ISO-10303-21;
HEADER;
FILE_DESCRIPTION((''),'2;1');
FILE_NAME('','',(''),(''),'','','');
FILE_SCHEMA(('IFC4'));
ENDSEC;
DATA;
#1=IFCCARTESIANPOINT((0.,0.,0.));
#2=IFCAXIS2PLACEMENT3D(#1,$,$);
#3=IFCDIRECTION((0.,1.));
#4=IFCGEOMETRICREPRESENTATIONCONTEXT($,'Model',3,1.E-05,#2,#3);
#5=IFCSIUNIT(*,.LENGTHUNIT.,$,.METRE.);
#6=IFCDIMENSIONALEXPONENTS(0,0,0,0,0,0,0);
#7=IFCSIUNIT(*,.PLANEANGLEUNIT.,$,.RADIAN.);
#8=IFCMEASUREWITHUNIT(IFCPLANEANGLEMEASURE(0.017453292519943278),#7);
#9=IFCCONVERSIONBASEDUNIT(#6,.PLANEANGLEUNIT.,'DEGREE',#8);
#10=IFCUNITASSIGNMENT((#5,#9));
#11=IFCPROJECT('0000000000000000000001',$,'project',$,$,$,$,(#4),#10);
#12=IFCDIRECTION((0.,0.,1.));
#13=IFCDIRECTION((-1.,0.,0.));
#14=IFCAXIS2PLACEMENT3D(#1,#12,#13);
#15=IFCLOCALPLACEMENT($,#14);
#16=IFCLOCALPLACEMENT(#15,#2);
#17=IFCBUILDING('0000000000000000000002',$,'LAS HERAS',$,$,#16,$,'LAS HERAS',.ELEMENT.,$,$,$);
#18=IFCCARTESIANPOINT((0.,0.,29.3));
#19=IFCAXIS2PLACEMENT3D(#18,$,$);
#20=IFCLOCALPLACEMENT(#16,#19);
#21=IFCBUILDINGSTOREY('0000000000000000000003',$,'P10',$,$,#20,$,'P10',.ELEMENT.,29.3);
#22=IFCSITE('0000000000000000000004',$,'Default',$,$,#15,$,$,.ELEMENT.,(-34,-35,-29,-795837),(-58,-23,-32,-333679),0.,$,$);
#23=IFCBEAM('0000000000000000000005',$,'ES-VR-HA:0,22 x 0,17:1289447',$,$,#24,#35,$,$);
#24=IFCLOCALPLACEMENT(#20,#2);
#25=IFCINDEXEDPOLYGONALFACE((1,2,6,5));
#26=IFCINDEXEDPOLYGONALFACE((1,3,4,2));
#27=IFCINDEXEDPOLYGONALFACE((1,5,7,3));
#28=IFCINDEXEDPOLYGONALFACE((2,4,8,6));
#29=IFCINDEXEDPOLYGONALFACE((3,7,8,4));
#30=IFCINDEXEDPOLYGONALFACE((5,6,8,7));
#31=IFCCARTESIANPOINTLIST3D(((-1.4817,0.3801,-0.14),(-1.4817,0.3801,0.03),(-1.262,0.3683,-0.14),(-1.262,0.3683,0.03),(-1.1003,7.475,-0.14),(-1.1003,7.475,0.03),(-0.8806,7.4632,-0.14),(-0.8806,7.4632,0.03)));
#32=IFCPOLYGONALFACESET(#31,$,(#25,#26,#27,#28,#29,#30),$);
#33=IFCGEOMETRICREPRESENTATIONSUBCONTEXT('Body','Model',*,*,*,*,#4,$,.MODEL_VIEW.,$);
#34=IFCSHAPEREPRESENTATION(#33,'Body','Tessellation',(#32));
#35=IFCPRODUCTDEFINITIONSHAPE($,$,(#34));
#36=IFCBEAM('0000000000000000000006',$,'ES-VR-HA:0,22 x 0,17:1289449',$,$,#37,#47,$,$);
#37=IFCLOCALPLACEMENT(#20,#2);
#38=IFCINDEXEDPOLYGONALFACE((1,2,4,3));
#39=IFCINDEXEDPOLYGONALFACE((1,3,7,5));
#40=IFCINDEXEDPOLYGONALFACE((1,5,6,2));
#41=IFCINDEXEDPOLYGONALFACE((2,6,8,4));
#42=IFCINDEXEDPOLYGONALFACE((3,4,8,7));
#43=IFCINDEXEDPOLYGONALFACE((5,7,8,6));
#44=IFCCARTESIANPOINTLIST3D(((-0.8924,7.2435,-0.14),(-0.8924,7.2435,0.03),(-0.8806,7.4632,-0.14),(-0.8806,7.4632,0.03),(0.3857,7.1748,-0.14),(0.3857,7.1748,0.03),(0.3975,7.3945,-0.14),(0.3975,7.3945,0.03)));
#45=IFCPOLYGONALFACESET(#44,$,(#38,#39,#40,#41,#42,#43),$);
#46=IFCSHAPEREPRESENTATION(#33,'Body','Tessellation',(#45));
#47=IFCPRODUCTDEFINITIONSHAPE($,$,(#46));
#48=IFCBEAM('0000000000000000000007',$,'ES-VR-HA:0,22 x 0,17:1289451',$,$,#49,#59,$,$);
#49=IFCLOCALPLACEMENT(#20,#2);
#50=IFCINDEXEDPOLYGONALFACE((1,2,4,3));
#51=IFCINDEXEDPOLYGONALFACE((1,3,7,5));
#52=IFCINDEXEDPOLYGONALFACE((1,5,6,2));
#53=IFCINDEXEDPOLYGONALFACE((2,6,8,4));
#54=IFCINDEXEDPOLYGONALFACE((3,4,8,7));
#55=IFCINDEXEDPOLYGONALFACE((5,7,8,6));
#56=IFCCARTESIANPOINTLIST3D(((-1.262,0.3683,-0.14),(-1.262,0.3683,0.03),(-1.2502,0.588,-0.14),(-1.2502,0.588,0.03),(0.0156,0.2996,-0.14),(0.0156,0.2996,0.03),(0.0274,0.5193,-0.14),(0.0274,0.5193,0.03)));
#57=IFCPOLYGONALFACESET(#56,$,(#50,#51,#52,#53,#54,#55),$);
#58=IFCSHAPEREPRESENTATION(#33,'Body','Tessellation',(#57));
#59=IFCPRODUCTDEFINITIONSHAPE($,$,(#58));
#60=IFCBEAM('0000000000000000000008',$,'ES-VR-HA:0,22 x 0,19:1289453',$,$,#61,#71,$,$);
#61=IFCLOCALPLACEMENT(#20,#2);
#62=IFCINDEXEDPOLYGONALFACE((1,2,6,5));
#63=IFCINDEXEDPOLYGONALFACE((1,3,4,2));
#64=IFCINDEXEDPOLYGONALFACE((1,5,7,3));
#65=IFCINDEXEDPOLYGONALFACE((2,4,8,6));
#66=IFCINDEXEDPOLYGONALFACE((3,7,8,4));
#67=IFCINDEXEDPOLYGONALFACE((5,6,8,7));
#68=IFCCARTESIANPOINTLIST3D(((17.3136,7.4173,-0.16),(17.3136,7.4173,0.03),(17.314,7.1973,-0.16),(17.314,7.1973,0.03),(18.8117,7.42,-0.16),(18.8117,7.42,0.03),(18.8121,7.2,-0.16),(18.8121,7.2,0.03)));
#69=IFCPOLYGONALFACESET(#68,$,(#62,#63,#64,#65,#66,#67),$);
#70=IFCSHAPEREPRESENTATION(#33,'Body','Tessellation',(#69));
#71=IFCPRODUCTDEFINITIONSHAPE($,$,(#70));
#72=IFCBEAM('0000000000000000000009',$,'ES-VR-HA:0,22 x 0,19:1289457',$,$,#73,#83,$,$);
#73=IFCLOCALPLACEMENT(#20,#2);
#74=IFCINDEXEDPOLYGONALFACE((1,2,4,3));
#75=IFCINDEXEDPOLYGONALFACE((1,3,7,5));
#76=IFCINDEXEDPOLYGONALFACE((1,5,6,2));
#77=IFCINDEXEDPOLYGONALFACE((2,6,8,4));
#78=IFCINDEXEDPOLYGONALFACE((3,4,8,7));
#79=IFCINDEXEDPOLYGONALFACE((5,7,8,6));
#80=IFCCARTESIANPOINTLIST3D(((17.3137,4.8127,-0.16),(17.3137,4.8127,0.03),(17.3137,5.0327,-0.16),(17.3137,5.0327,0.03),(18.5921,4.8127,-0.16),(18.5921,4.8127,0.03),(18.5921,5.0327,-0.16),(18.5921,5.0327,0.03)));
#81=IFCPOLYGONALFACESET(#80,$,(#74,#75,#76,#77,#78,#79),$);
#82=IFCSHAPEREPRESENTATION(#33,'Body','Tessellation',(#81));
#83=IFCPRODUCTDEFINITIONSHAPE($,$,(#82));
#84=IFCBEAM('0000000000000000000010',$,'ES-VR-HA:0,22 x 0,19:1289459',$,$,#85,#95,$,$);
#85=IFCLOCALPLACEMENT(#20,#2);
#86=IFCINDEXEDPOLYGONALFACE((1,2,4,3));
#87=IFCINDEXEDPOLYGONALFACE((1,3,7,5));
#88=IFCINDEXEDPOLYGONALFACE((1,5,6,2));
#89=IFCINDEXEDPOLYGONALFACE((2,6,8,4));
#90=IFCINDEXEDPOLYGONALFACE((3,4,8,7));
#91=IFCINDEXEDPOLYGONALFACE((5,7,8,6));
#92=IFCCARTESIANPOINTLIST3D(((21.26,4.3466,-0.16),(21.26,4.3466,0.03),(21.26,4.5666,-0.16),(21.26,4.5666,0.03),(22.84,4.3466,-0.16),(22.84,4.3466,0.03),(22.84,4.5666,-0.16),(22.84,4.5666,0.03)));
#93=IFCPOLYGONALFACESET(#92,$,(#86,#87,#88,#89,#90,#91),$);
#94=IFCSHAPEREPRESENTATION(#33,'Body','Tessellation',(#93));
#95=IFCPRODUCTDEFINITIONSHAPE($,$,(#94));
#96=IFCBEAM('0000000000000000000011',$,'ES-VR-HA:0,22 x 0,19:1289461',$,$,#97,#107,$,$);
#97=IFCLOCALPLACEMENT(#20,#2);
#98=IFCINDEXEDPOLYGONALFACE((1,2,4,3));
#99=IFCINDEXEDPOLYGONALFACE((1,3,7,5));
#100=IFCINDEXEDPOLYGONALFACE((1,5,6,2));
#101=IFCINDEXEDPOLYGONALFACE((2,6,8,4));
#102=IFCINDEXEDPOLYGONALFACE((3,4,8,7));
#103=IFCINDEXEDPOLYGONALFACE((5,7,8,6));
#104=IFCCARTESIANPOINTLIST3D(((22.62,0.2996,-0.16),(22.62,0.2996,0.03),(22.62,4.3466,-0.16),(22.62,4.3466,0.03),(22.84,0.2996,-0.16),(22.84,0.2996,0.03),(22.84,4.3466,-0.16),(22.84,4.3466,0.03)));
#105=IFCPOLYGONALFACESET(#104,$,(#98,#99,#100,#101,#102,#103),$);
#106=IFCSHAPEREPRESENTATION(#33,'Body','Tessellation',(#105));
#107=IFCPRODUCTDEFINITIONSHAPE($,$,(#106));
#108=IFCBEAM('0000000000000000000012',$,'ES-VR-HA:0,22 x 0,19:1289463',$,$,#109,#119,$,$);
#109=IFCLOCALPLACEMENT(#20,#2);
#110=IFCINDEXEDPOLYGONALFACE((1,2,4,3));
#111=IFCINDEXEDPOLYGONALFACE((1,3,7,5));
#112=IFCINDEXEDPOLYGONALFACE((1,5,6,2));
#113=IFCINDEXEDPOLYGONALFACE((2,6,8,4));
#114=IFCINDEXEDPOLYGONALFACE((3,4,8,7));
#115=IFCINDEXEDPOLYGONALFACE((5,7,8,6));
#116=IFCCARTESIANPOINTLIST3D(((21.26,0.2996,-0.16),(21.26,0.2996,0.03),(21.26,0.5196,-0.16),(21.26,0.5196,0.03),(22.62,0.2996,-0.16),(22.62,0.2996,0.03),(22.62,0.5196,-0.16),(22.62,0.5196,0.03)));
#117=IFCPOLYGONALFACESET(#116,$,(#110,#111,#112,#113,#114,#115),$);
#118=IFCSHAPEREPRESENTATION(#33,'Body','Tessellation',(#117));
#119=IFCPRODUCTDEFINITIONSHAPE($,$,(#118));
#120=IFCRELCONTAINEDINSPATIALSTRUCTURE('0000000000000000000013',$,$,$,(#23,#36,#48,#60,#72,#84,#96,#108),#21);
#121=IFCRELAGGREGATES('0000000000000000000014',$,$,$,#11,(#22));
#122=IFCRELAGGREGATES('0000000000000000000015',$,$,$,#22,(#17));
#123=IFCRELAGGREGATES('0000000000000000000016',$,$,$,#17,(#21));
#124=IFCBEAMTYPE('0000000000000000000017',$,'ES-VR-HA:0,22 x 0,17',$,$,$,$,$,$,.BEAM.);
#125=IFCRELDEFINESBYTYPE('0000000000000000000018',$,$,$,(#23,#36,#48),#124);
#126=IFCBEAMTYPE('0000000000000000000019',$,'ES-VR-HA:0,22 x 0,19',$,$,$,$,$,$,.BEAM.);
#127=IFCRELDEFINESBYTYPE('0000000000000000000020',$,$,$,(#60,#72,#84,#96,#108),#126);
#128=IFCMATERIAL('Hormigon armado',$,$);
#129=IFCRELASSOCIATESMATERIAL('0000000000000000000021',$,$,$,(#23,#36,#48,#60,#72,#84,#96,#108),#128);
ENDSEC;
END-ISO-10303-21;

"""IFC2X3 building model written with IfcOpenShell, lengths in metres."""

from ifc_helpers import new_model, entity, si_unit, converted_unit, direction, frame, frame_2d, origin, origin_2d_with_axis, place, context, subcontext, project, spatial, rectangle, extrude, material, type_object, element, save


model = new_model("IFC2X3")

# Units and contexts
model_context = context("Model", 3, precision=1e-05, world=origin(), true_north=direction((0.0, 1.0)))
body_context = subcontext(model_context, "Body", "Model", "MODEL_VIEW")
ifc_project = project(units=[si_unit("LENGTHUNIT", "METRE"), converted_unit("PLANEANGLEUNIT", "DEGREE", entity("IfcPlaneAngleMeasure", 0.017453292519943278), si_unit("PLANEANGLEUNIT", "RADIAN"), dimensions=[0, 0, 0, 0, 0, 0, 0])], contexts=[model_context])

# Site, building, storey
site_placement = place(None, frame((0.0, 0.0, 0.0), z_axis=(0.0, 0.0, 1.0), x_axis=(-1.0, 0.0, 0.0)))
site = spatial("IfcSite", under=ifc_project, at=site_placement, Name="Default", CompositionType="ELEMENT", RefLatitude=(-34, -35, -29, -795837), RefLongitude=(-58, -23, -32, -333679), RefElevation=0.0)
building_placement = place(site_placement, origin())
building = spatial("IfcBuilding", under=site, at=building_placement, Name="LAS HERAS", LongName="LAS HERAS", CompositionType="ELEMENT")
storey_placement = place(building_placement, frame((0.0, 0.0, 29.3)))
storey = spatial("IfcBuildingStorey", under=building, at=storey_placement, Name="P10", LongName="P10", CompositionType="ELEMENT", Elevation=29.3)

# Beams
ifc_material = material(Name="Hormigon armado")
beam_type_1 = type_object("IfcBeamType", Name="ES-VR-HA:0,22 x 0,17", PredefinedType="BEAM")
beam_1_placement = place(storey_placement, frame((-0.9963, 7.3593, 0.03), z_axis=(0.0, 0.0, 1.0), x_axis=(-0.05369, -0.998558, 0.0)))
element("IfcBeam", 1, at=beam_1_placement, inside=storey, type_object=beam_type_1, material=ifc_material, Name="ES-VR-HA:0,22 x 0,17:1289447", context=body_context, shape_type="SweptSolid", body=[
    extrude(rectangle(XDim=0.17, YDim=0.22, at=frame_2d((0.0, 0.0), x_axis=(1.0, 0.0))), frame((-0.11, 0.0, -0.085), z_axis=(1.0, 0.0, 0.0), x_axis=(0.0, 0.0, -1.0)), (0.0, 0.0, 1.0), 7.1052),
])
beam_2_placement = place(storey_placement, frame((0.3916, 7.2846, 0.03), z_axis=(0.0, 0.0, 1.0), x_axis=(-0.998558, 0.05368, 0.0)))
element("IfcBeam", 2, at=beam_2_placement, inside=storey, type_object=beam_type_1, material=ifc_material, Name="ES-VR-HA:0,22 x 0,17:1289449", context=body_context, shape_type="SweptSolid", body=[
    extrude(rectangle(XDim=0.17, YDim=0.22, at=frame_2d((0.0, 0.0), x_axis=(1.0, 0.0))), frame((0.0, 0.0, -0.085), z_axis=(1.0, 0.0, 0.0), x_axis=(0.0, 0.0, -1.0)), (0.0, 0.0, 1.0), 1.28),
])
beam_3_placement = place(storey_placement, frame((0.0215, 0.4094, 0.03), z_axis=(0.0, 0.0, 1.0), x_axis=(-0.998558, 0.05369, 0.0)))
element("IfcBeam", 3, at=beam_3_placement, inside=storey, type_object=beam_type_1, material=ifc_material, Name="ES-VR-HA:0,22 x 0,17:1289451", context=body_context, shape_type="SweptSolid", body=[
    extrude(rectangle(XDim=0.17, YDim=0.22, at=frame_2d((0.0, 0.0), x_axis=(1.0, 0.0))), frame((0.0, 0.0, -0.085), z_axis=(1.0, 0.0, 0.0), x_axis=(0.0, 0.0, -1.0)), (0.0, 0.0, 1.0), 1.2795),
])
beam_type_2 = type_object("IfcBeamType", Name="ES-VR-HA:0,22 x 0,19", PredefinedType="BEAM")
beam_4_placement = place(storey_placement, frame((17.3138, 7.3073, 0.03), z_axis=(0.0, 0.0, 1.0), x_axis=(0.999998, 0.001781, 0.0)))
element("IfcBeam", 4, at=beam_4_placement, inside=storey, type_object=beam_type_2, material=ifc_material, Name="ES-VR-HA:0,22 x 0,19:1289453", context=body_context, shape_type="SweptSolid", body=[
    extrude(rectangle(XDim=0.19, YDim=0.22, at=frame_2d((0.0, 0.0), x_axis=(1.0, 0.0))), frame((0.0, 0.0, -0.095), z_axis=(1.0, 0.0, 0.0), x_axis=(0.0, 0.0, -1.0)), (0.0, 0.0, 1.0), 1.4981),
])
beam_5_placement = place(storey_placement, frame((17.3137, 4.9227, 0.03)))
element("IfcBeam", 5, at=beam_5_placement, inside=storey, type_object=beam_type_2, material=ifc_material, Name="ES-VR-HA:0,22 x 0,19:1289457", context=body_context, shape_type="SweptSolid", body=[
    extrude(rectangle(XDim=0.19, YDim=0.22, at=frame_2d((0.0, 0.0), x_axis=(1.0, 0.0))), frame((0.0, 0.0, -0.095), z_axis=(1.0, 0.0, 0.0), x_axis=(0.0, 0.0, -1.0)), (0.0, 0.0, 1.0), 1.2784),
])
beam_6_placement = place(storey_placement, frame((21.26, 4.4566, 0.03)))
element("IfcBeam", 6, at=beam_6_placement, inside=storey, type_object=beam_type_2, material=ifc_material, Name="ES-VR-HA:0,22 x 0,19:1289459", context=body_context, shape_type="SweptSolid", body=[
    extrude(rectangle(XDim=0.19, YDim=0.22, at=origin_2d_with_axis()), frame((0.0, 0.0, -0.095), z_axis=(1.0, 0.0, 0.0), x_axis=(0.0, 0.0, -1.0)), (0.0, 0.0, 1.0), 1.58),
])
beam_7_placement = place(storey_placement, frame((22.73, 4.4566, 0.03), z_axis=(0.0, 0.0, 1.0), x_axis=(0.0, -1.0, 0.0)))
element("IfcBeam", 7, at=beam_7_placement, inside=storey, type_object=beam_type_2, material=ifc_material, Name="ES-VR-HA:0,22 x 0,19:1289461", context=body_context, shape_type="SweptSolid", body=[
    extrude(rectangle(XDim=0.19, YDim=0.22, at=frame_2d((0.0, 0.0), x_axis=(1.0, 0.0))), frame((0.11, 0.0, -0.095), z_axis=(1.0, 0.0, 0.0), x_axis=(0.0, 0.0, -1.0)), (0.0, 0.0, 1.0), 4.0471),
])
beam_8_placement = place(storey_placement, frame((21.26, 0.4096, 0.03)))
element("IfcBeam", 8, at=beam_8_placement, inside=storey, type_object=beam_type_2, material=ifc_material, Name="ES-VR-HA:0,22 x 0,19:1289463", context=body_context, shape_type="SweptSolid", body=[
    extrude(rectangle(XDim=0.19, YDim=0.22, at=frame_2d((0.0, 0.0), x_axis=(1.0, 0.0))), frame((0.0, 0.0, -0.095), z_axis=(1.0, 0.0, 0.0), x_axis=(0.0, 0.0, -1.0)), (0.0, 0.0, 1.0), 1.36),
])

save(model, "model.ifc")
